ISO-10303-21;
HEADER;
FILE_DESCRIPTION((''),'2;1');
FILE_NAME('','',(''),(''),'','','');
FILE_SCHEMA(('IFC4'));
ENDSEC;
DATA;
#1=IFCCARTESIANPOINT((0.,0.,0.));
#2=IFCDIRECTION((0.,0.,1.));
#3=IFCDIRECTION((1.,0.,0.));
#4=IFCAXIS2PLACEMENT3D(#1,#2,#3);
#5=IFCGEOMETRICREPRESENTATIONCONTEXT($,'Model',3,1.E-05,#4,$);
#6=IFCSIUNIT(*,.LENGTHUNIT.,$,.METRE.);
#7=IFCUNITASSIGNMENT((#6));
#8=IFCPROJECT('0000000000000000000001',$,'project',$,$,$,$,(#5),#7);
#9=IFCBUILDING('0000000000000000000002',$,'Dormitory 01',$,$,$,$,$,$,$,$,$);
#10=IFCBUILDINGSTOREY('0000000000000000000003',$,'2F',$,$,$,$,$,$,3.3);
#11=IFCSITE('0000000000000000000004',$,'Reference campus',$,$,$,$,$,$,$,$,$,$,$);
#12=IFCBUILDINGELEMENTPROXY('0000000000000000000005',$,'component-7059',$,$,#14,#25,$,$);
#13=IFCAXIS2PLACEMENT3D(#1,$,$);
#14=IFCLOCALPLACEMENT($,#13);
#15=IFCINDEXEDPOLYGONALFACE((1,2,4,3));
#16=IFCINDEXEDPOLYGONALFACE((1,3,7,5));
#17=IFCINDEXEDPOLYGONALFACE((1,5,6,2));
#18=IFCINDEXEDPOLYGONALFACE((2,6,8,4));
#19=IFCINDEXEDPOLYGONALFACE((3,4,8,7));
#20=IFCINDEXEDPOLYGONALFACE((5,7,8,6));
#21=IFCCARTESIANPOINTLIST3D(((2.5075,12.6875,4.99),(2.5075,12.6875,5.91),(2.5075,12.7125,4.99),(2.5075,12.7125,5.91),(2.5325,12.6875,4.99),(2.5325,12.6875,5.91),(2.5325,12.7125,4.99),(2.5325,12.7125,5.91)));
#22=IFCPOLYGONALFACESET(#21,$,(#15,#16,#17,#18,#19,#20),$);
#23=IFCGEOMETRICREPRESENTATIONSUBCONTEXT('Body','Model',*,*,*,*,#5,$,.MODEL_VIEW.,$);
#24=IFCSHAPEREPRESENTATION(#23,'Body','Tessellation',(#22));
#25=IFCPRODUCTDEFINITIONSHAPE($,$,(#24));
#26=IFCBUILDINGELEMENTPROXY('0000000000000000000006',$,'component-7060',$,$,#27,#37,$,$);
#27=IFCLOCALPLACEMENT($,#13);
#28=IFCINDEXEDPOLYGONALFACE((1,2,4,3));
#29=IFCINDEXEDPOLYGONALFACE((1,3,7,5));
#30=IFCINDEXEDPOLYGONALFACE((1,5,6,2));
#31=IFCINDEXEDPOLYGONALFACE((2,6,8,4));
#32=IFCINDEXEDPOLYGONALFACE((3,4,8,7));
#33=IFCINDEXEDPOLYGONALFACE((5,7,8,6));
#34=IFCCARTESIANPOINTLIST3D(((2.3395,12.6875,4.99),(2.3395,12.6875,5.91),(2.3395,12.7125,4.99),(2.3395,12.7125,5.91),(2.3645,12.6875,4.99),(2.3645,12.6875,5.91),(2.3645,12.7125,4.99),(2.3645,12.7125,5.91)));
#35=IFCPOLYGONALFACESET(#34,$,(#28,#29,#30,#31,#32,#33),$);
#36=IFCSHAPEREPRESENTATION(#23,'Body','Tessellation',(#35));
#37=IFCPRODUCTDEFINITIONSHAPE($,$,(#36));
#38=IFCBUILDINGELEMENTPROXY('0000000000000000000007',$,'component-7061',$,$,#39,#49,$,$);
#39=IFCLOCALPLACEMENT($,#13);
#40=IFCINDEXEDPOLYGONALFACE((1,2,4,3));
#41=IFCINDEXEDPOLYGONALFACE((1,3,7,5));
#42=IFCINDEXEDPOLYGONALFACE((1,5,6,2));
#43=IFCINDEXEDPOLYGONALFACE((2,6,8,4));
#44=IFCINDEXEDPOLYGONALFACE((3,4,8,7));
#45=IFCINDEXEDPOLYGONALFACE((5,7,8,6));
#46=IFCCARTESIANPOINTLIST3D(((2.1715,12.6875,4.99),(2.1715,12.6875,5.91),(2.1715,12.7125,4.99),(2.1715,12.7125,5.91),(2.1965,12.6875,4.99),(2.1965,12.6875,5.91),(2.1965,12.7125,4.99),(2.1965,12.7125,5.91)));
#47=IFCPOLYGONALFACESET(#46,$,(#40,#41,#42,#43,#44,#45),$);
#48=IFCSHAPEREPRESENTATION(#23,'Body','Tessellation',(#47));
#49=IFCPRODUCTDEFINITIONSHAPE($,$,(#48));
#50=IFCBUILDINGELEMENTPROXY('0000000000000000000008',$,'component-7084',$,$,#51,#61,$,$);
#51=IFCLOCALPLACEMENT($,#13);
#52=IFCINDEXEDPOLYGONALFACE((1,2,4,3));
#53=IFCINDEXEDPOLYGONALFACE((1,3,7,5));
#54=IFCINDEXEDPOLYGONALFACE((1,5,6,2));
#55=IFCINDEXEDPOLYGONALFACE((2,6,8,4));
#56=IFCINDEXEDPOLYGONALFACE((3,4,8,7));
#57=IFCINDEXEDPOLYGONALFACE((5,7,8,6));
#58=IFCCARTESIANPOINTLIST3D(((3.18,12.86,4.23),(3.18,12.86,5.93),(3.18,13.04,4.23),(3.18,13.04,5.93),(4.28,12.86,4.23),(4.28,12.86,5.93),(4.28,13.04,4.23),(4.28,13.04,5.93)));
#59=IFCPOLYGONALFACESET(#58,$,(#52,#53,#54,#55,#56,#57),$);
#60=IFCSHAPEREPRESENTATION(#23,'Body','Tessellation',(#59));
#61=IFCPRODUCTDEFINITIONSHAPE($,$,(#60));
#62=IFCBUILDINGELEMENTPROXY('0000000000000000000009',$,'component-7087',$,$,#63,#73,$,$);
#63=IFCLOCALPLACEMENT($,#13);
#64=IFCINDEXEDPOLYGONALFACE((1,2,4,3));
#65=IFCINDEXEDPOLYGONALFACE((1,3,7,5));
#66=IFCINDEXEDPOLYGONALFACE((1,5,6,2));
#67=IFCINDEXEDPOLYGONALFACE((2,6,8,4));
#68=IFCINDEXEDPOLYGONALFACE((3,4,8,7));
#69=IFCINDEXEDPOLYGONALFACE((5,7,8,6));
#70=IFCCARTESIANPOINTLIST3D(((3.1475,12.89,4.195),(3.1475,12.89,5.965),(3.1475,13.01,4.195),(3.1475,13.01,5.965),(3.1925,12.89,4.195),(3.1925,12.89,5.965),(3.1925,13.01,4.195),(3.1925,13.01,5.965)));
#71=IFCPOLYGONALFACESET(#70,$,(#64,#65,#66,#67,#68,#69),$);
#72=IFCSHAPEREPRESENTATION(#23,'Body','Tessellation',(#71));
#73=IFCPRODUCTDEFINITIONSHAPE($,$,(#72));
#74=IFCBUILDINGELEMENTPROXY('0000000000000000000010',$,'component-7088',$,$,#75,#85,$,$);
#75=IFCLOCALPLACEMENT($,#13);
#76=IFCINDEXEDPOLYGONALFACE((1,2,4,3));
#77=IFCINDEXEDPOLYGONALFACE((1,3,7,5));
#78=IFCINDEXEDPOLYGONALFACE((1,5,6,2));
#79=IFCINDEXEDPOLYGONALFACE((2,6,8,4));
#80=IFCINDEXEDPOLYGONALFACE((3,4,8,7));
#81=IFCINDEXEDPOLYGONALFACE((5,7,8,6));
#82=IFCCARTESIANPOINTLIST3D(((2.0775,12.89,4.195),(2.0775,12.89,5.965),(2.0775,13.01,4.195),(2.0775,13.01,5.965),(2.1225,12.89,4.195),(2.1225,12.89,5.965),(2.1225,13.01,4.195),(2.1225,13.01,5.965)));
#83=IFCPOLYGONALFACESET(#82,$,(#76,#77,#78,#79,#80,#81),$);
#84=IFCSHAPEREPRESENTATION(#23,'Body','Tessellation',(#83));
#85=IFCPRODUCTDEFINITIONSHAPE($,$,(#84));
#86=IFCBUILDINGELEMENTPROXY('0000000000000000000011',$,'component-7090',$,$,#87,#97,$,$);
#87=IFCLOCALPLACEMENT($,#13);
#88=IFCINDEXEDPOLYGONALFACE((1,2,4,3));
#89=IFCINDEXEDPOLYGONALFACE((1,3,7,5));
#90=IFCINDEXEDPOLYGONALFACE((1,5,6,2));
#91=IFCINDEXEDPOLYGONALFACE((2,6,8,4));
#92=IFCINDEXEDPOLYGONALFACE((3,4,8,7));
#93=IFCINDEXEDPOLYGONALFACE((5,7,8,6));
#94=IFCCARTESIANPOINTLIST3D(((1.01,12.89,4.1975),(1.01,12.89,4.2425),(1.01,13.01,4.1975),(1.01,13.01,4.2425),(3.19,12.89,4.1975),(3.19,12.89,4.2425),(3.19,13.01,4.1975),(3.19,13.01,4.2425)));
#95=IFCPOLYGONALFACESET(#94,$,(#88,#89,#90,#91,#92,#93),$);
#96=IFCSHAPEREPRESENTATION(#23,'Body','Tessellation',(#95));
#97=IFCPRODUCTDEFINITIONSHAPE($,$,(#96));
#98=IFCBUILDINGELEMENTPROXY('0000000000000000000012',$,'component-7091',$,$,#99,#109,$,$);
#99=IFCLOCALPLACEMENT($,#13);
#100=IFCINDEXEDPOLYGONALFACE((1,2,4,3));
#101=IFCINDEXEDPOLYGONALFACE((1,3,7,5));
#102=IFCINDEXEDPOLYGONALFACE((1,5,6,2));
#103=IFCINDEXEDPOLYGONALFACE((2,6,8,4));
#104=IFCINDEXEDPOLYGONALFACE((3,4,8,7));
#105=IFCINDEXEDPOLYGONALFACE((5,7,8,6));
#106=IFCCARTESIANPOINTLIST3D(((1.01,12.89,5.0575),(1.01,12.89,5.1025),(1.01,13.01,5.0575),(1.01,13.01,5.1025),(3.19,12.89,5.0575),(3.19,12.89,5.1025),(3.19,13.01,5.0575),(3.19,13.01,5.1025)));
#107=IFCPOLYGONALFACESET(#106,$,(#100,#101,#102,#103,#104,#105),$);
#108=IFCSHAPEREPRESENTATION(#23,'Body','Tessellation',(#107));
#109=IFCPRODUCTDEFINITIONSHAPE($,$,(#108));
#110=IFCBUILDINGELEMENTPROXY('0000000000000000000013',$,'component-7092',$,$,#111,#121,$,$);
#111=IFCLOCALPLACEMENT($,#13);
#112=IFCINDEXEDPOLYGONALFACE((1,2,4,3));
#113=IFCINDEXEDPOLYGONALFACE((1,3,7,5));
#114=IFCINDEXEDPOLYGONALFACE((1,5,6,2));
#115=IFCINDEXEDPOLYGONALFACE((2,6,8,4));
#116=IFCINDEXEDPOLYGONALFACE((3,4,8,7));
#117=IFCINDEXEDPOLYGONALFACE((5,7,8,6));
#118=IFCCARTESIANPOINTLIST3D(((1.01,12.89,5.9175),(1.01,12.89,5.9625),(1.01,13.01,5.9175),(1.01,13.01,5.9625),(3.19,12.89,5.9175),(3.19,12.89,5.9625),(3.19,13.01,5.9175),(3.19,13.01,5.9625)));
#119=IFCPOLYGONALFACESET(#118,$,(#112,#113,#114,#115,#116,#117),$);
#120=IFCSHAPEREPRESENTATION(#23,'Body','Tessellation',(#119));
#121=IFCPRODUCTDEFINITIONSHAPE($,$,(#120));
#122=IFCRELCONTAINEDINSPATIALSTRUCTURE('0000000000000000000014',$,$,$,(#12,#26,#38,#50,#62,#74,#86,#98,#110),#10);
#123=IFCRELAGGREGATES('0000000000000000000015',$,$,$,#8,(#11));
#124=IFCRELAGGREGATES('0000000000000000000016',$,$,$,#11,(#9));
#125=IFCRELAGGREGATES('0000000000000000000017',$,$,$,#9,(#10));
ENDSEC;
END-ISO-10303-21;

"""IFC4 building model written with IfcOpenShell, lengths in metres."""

from ifc_helpers import new_model, si_unit, frame, origin, origin_with_axes, origin_2d, place, context, subcontext, project, spatial, rectangle, extrude, element, save


model = new_model("IFC4")

# Units and contexts
model_context = context("Model", 3, precision=1e-05, world=origin_with_axes())
body_context = subcontext(model_context, "Body", "Model", "MODEL_VIEW")
ifc_project = project(units=[si_unit("LENGTHUNIT", "METRE")], contexts=[model_context])

# Site, building, storey
site = spatial("IfcSite", under=ifc_project, Name="Reference campus")
building = spatial("IfcBuilding", under=site, Name="Dormitory 01")
storey = spatial("IfcBuildingStorey", under=building, Name="2F", Elevation=3.3)

# Building element proxies
for number, where, z_axis, x_axis, name in (
    (1, (2.52, 12.7, 4.99), (0.0, 0.0, 1.0), (-1.0, 0.0, 0.0), "component-7059"),
    (2, (2.352, 12.7, 4.99), (0.0, 0.0, 1.0), (-1.0, 0.0, 0.0), "component-7060"),
    (3, (2.184, 12.7, 4.99), (0.0, 0.0, 1.0), (-1.0, 0.0, 0.0), "component-7061"),
):
    element("IfcBuildingElementProxy", number, at=place(None, frame(where, z_axis=z_axis, x_axis=x_axis)), inside=storey, Name=name, context=body_context, shape_type="SweptSolid", body=[
        extrude(rectangle(XDim=0.025, YDim=0.025, at=origin_2d()), origin(), (0.0, 0.0, 1.0), 0.92),
    ])
proxy_placement = place(None, frame((3.73, 12.95, 4.23), z_axis=(0.0, 0.0, 1.0), x_axis=(-1.0, 0.0, 0.0)))
element("IfcBuildingElementProxy", 4, at=proxy_placement, inside=storey, Name="component-7084", context=body_context, shape_type="SweptSolid", body=[
    extrude(rectangle(XDim=1.1, YDim=0.18, at=origin_2d()), origin(), (0.0, 0.0, 1.0), 1.7),
])
for number, where, z_axis, x_axis, name in (
    (5, (3.17, 12.95, 4.195), (0.0, 0.0, 1.0), (-1.0, 0.0, 0.0), "component-7087"),
    (6, (2.1, 12.95, 4.195), (0.0, 0.0, 1.0), (-1.0, 0.0, 0.0), "component-7088"),
):
    element("IfcBuildingElementProxy", number, at=place(None, frame(where, z_axis=z_axis, x_axis=x_axis)), inside=storey, Name=name, context=body_context, shape_type="SweptSolid", body=[
        extrude(rectangle(XDim=0.045, YDim=0.12, at=origin_2d()), origin(), (0.0, 0.0, 1.0), 1.77),
    ])
for number, where, z_axis, x_axis, name in (
    (7, (2.1, 12.95, 4.1975), (0.0, 0.0, 1.0), (-1.0, 0.0, 0.0), "component-7090"),
    (8, (2.1, 12.95, 5.0575), (0.0, 0.0, 1.0), (-1.0, 0.0, 0.0), "component-7091"),
    (9, (2.1, 12.95, 5.9175), (0.0, 0.0, 1.0), (-1.0, 0.0, 0.0), "component-7092"),
):
    element("IfcBuildingElementProxy", number, at=place(None, frame(where, z_axis=z_axis, x_axis=x_axis)), inside=storey, Name=name, context=body_context, shape_type="SweptSolid", body=[
        extrude(rectangle(XDim=2.18, YDim=0.12, at=origin_2d()), origin(), (0.0, 0.0, 1.0), 0.045),
    ])

save(model, "model.ifc")
